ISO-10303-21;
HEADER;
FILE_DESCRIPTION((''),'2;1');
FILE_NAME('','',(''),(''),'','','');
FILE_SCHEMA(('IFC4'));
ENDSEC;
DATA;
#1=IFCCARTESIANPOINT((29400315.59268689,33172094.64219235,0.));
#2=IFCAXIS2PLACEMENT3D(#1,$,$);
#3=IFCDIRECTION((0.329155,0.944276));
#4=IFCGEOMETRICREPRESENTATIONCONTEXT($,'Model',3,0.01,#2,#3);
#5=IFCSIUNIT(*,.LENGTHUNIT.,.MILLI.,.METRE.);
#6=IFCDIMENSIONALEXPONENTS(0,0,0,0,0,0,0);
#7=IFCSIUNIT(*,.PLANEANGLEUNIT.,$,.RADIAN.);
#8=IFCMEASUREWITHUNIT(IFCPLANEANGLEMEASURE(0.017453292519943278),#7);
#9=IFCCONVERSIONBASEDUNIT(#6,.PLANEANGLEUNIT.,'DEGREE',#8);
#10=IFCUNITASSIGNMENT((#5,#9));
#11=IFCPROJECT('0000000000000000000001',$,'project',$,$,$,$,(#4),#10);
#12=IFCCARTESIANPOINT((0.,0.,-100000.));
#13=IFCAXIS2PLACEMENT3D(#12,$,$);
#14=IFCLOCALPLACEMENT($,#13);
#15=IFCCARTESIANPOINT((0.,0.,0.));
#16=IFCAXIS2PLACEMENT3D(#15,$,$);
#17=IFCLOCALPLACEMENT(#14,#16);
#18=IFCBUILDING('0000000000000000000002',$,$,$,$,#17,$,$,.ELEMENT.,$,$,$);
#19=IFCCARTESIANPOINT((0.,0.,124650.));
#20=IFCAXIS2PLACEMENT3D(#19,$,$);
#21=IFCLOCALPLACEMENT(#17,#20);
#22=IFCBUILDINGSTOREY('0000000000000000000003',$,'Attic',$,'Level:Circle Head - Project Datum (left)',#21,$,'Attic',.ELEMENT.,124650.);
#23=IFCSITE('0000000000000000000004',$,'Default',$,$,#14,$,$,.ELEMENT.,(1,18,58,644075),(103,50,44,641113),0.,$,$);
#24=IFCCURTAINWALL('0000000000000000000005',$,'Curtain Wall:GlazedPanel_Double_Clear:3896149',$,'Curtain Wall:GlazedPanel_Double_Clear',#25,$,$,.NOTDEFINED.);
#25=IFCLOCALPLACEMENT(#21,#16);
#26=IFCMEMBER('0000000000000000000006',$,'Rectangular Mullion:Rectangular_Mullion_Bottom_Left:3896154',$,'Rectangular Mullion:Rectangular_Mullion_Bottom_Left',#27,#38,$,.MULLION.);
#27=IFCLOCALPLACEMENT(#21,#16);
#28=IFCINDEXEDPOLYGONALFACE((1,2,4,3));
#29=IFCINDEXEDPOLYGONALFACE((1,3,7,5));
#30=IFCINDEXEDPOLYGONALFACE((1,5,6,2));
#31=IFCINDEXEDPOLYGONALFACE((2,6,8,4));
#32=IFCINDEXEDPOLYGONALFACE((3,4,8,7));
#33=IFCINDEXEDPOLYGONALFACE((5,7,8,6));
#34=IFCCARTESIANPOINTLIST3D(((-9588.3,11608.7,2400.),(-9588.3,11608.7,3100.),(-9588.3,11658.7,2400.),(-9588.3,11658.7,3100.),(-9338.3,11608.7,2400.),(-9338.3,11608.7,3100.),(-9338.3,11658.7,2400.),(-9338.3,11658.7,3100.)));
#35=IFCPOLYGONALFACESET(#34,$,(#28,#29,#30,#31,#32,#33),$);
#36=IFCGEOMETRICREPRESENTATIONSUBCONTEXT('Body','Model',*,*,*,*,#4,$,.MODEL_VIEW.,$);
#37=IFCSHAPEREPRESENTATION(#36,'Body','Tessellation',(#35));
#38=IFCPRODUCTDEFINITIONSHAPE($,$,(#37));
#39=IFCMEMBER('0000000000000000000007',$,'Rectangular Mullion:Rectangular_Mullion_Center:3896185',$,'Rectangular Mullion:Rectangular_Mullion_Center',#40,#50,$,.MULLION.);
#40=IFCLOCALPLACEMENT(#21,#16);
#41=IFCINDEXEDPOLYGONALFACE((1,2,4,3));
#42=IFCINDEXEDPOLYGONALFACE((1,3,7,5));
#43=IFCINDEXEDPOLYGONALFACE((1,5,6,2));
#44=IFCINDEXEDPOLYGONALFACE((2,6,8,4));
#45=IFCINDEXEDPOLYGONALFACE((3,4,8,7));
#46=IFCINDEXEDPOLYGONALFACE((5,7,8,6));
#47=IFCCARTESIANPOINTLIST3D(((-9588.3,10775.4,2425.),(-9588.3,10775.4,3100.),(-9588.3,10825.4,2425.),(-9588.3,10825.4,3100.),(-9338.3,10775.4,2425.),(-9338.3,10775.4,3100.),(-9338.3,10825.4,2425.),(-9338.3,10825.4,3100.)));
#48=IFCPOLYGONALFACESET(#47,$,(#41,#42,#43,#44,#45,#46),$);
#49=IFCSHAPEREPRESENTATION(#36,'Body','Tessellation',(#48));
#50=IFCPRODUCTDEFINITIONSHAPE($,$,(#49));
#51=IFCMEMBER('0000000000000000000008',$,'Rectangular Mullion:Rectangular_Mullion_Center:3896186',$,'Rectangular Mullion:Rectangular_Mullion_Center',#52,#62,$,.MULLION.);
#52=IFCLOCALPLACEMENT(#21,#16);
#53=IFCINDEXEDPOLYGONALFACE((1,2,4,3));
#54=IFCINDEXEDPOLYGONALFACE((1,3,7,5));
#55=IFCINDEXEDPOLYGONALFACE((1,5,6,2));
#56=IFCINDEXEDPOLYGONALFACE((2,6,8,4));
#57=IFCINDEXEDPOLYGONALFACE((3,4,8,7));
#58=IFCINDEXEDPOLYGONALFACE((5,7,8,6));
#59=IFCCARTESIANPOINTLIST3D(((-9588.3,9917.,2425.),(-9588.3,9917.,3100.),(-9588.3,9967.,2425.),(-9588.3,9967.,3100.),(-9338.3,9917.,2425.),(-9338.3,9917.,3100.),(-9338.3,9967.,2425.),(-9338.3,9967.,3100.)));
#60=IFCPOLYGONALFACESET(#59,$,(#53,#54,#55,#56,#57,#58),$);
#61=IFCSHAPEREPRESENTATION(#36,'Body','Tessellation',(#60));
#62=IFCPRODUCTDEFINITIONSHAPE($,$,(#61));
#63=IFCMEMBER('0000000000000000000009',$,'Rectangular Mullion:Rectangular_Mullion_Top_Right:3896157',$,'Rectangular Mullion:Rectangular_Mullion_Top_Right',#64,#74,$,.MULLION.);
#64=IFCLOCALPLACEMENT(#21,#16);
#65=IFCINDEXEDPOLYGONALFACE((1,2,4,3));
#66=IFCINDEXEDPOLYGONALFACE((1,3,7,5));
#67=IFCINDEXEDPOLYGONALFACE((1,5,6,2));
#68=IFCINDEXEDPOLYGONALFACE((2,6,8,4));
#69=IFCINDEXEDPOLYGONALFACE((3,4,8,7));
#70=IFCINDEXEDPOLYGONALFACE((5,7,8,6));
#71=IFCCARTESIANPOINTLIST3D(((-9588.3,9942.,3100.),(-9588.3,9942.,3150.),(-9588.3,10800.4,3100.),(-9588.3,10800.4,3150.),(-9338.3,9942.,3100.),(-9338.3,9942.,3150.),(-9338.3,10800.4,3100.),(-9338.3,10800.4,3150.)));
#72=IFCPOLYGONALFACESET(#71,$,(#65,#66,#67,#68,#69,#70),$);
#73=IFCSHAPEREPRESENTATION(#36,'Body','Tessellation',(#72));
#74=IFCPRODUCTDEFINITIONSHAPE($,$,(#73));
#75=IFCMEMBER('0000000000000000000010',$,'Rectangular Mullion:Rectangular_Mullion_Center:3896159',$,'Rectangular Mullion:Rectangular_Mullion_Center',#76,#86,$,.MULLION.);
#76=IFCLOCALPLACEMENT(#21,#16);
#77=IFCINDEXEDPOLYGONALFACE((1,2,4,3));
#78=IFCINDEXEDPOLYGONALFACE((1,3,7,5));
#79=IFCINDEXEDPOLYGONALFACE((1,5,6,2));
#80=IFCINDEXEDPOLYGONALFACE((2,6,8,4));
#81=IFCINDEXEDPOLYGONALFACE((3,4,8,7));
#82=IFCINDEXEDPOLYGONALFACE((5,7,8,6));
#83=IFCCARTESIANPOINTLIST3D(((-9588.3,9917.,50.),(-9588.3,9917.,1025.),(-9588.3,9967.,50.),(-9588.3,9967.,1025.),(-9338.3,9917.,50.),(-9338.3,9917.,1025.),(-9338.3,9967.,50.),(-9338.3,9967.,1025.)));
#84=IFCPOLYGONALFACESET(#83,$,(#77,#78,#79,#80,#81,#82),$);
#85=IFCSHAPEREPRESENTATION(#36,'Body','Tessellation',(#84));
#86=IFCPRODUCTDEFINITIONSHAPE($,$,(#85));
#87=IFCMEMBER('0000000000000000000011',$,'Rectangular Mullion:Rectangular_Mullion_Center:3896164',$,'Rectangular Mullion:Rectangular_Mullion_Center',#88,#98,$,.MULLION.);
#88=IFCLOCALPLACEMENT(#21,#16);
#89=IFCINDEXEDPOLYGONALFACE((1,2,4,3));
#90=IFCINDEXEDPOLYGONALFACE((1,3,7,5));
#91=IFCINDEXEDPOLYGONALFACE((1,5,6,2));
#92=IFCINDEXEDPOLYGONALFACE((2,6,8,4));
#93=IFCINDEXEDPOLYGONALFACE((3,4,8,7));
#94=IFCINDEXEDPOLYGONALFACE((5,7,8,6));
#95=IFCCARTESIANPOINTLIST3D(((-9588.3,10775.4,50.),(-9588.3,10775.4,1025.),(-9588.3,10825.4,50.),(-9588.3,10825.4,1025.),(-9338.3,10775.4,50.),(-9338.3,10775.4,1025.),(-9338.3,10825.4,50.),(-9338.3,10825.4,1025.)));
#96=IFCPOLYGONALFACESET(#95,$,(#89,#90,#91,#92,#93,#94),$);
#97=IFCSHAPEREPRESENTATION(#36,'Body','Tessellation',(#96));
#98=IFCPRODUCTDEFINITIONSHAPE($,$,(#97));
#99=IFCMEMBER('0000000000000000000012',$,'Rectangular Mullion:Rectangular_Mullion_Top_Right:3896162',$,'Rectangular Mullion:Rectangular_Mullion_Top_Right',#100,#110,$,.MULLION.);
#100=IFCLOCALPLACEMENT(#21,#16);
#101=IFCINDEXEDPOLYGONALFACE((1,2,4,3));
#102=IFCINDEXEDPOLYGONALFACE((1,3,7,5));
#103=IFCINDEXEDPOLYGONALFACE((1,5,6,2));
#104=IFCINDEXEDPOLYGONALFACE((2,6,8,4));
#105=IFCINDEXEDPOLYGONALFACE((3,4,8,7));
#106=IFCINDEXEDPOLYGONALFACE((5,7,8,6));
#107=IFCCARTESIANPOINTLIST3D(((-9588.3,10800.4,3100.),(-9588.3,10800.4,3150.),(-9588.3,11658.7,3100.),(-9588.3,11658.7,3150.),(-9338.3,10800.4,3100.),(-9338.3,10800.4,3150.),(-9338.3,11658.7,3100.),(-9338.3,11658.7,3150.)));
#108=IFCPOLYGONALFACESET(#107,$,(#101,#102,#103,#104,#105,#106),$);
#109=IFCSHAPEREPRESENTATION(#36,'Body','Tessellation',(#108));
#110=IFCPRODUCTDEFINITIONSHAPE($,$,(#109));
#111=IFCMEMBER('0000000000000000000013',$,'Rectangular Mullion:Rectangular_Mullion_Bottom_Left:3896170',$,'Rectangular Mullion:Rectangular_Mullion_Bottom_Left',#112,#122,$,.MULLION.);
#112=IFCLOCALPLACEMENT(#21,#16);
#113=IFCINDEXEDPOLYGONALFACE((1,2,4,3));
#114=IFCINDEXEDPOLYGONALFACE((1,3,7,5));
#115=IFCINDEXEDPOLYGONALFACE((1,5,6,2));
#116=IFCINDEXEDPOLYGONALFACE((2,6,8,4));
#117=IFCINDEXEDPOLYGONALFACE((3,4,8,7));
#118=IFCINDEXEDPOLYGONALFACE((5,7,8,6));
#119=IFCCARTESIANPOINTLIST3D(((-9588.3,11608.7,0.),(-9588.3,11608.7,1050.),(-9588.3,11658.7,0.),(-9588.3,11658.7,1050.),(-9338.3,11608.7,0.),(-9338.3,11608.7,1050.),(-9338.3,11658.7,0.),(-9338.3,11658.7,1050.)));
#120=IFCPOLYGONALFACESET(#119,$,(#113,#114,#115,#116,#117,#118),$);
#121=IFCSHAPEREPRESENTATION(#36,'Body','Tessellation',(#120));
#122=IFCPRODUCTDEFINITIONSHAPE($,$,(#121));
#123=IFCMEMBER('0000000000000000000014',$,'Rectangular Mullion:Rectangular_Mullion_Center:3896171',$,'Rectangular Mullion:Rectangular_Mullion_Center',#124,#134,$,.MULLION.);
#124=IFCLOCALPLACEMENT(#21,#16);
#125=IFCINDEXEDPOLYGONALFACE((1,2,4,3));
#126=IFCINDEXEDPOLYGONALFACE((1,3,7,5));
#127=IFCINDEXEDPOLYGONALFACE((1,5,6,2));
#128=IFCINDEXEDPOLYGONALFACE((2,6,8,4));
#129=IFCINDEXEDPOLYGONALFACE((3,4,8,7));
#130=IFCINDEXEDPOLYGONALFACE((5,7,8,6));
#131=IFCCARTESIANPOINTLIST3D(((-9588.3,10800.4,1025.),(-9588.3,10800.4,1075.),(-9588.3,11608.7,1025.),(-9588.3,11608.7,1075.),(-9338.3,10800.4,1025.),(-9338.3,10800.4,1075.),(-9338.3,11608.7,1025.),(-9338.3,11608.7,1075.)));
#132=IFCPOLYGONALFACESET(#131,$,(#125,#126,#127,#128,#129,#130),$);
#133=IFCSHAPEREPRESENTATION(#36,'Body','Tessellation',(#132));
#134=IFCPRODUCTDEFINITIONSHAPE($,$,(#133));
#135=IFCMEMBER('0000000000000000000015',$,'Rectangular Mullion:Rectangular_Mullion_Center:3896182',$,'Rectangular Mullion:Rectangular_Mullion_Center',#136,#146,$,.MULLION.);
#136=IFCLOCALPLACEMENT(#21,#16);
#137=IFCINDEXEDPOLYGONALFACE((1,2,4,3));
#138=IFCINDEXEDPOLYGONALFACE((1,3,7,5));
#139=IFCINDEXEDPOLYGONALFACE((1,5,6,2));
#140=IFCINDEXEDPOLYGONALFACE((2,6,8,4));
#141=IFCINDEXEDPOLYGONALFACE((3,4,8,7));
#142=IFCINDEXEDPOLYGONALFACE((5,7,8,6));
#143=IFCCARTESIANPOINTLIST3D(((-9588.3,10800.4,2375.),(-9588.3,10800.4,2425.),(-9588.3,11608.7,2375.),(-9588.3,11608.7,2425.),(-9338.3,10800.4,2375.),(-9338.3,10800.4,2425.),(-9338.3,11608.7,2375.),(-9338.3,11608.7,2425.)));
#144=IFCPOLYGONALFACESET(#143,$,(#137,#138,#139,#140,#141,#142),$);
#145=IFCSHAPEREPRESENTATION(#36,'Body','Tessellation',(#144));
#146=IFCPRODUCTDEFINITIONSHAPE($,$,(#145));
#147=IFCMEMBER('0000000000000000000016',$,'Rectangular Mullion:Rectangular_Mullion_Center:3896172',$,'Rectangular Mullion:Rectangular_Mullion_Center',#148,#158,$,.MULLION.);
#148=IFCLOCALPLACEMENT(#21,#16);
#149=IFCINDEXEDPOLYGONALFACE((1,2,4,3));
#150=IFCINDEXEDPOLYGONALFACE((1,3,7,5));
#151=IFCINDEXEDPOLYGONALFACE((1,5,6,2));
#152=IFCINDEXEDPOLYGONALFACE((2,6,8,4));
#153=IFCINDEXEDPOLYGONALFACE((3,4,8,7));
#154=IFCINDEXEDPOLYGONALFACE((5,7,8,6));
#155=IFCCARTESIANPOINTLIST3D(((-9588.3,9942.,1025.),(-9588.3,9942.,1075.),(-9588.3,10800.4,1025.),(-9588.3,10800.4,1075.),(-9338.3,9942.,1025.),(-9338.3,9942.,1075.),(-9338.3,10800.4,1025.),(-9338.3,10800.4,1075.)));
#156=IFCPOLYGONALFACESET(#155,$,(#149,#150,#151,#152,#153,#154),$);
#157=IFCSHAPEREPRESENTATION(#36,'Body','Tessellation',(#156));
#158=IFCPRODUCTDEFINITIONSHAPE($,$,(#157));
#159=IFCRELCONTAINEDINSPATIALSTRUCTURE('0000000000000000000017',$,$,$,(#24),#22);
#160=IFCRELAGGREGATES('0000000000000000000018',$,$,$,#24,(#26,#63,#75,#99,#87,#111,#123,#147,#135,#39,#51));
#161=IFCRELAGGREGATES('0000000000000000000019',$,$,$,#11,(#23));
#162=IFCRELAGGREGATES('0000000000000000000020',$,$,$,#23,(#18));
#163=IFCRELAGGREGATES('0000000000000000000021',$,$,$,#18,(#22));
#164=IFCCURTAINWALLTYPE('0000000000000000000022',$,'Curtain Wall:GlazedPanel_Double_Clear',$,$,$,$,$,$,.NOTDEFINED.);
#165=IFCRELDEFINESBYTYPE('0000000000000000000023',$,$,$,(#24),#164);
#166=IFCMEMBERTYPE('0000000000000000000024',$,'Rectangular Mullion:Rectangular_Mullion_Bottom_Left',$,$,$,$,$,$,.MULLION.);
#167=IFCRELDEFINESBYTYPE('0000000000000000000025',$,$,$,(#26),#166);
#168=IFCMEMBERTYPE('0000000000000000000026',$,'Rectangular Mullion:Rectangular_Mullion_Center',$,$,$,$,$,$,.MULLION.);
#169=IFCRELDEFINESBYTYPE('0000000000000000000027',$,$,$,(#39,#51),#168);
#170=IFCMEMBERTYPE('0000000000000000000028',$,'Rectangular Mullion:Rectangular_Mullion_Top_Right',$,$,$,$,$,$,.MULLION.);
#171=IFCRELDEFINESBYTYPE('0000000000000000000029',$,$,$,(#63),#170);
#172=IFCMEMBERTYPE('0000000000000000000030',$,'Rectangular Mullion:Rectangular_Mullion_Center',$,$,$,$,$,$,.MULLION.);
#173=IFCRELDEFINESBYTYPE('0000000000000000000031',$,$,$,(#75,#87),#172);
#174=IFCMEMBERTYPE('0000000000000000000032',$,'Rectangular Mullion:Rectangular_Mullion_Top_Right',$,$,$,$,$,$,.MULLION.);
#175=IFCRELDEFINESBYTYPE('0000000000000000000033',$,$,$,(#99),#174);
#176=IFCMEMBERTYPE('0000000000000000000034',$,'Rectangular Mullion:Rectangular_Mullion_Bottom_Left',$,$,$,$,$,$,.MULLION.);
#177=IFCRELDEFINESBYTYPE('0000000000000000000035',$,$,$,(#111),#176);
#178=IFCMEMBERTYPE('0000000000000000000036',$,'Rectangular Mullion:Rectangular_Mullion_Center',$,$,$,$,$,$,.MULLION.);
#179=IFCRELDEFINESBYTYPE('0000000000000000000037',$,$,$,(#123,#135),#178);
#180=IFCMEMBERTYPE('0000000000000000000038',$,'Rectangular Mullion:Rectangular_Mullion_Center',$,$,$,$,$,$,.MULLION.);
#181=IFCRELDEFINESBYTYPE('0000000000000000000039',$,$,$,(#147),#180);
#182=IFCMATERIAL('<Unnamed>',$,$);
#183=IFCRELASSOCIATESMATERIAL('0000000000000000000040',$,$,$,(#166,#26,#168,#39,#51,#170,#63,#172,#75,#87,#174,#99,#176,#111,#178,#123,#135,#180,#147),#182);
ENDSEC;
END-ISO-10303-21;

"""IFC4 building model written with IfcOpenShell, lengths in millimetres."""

from ifc_helpers import new_model, entity, si_unit, converted_unit, direction, frame, origin, place, context, subcontext, project, spatial, indexed_curve, outline, extrude, source, transform, mapped, material, type_object, type_shapes, element, aggregate, save


model = new_model("IFC4")

# Units and contexts
model_context = context("Model", 3, precision=0.01, world=frame((29400315.59268689, 33172094.64219235, 0.0)), true_north=direction((0.329155, 0.944276)))
body_context = subcontext(model_context, "Body", "Model", "MODEL_VIEW")
ifc_project = project(units=[si_unit("LENGTHUNIT", "METRE", prefix="MILLI"), converted_unit("PLANEANGLEUNIT", "DEGREE", entity("IfcPlaneAngleMeasure", 0.017453292519943278), si_unit("PLANEANGLEUNIT", "RADIAN"), dimensions=[0, 0, 0, 0, 0, 0, 0])], contexts=[model_context])

# Site, building, storey
site_placement = place(None, frame((0.0, 0.0, -100000.0)))
site = spatial("IfcSite", under=ifc_project, at=site_placement, Name="Default", CompositionType="ELEMENT", RefLatitude=(1, 18, 58, 644075), RefLongitude=(103, 50, 44, 641113), RefElevation=0.0)
building_placement = place(site_placement, origin())
building = spatial("IfcBuilding", under=site, at=building_placement, CompositionType="ELEMENT")
storey_placement = place(building_placement, frame((0.0, 0.0, 124650.0)))
storey = spatial("IfcBuildingStorey", under=building, at=storey_placement, Name="Attic", ObjectType="Level:Circle Head - Project Datum (left)", LongName="Attic", CompositionType="ELEMENT", Elevation=124650.0)

# Curtain wall, members
curtain_wall_type = type_object("IfcCurtainWallType", Name="Curtain Wall:GlazedPanel_Double_Clear", PredefinedType="NOTDEFINED")
curtain_wall_placement = place(storey_placement, frame((0.0, 0.0, -124650.0)))
curtain_wall = element("IfcCurtainWall", 1, at=curtain_wall_placement, inside=storey, type_object=curtain_wall_type, Name="Curtain Wall:GlazedPanel_Double_Clear:3896149", ObjectType="Curtain Wall:GlazedPanel_Double_Clear", PredefinedType="NOTDEFINED")
ifc_material_1 = material(Name="<Unnamed>")
member_type_1 = type_object("IfcMemberType", Name="Rectangular Mullion:Rectangular_Mullion_Bottom_Left", PredefinedType="MULLION", material=ifc_material_1)
shared_shape_1 = source(origin(), body_context, "Body", "SweptSolid", [
    extrude(outline(indexed_curve([(-25.0, -125.0), (25.0, -125.0), (25.0, 125.0), (-25.0, 125.0), (-25.0, -125.0)], self_intersect=False)), frame((-25.0, 0.0, -700.0), z_axis=(0.0, 0.0, 1.0), x_axis=(-1.0, 0.0, 0.0)), (0.0, 0.0, 1.0), 700.0),
])
type_shapes(member_type_1, [shared_shape_1])
member_1_placement = place(curtain_wall_placement, frame((-9463.3, 11658.7, 127750.0), z_axis=(0.0, 0.0, 1.0), x_axis=(0.0, 1.0, 0.0)))
member_1 = element("IfcMember", 2, at=member_1_placement, type_object=member_type_1, material=ifc_material_1, Name="Rectangular Mullion:Rectangular_Mullion_Bottom_Left:3896154", ObjectType="Rectangular Mullion:Rectangular_Mullion_Bottom_Left", PredefinedType="MULLION", context=body_context, shape_type="MappedRepresentation", body=[
    mapped(shared_shape_1, transform((0.0, 0.0, 0.0), scale=1.0)),
])
member_type_2 = type_object("IfcMemberType", Name="Rectangular Mullion:Rectangular_Mullion_Center", PredefinedType="MULLION", material=ifc_material_1)
shared_shape_2 = source(origin(), body_context, "Body", "SweptSolid", [
    extrude(outline(indexed_curve([(-25.0, -125.0), (25.0, -125.0), (25.0, 125.0), (-25.0, 125.0), (-25.0, -125.0)], self_intersect=False)), frame((0.0, 0.0, -675.0), z_axis=(0.0, 0.0, 1.0), x_axis=(-1.0, 0.0, 0.0)), (0.0, 0.0, 1.0), 675.0),
])
type_shapes(member_type_2, [shared_shape_2])
member_2_placement = place(curtain_wall_placement, frame((-9463.3, 10800.4, 127075.0), z_axis=(0.0, 0.0, -1.0), x_axis=(0.0, -1.0, 0.0)))
member_2 = element("IfcMember", 3, at=member_2_placement, type_object=member_type_2, material=ifc_material_1, Name="Rectangular Mullion:Rectangular_Mullion_Center:3896185", ObjectType="Rectangular Mullion:Rectangular_Mullion_Center", PredefinedType="MULLION", context=body_context, shape_type="MappedRepresentation", body=[
    mapped(shared_shape_2, transform((0.0, 0.0, 0.0), scale=1.0)),
])
member_3_placement = place(curtain_wall_placement, frame((-9463.3, 9942.0, 127075.0), z_axis=(0.0, 0.0, -1.0), x_axis=(0.0, -1.0, 0.0)))
member_3 = element("IfcMember", 4, at=member_3_placement, type_object=member_type_2, material=ifc_material_1, Name="Rectangular Mullion:Rectangular_Mullion_Center:3896186", ObjectType="Rectangular Mullion:Rectangular_Mullion_Center", PredefinedType="MULLION", context=body_context, shape_type="MappedRepresentation", body=[
    mapped(shared_shape_2, transform((0.0, 0.0, 0.0), scale=1.0)),
])
member_type_3 = type_object("IfcMemberType", Name="Rectangular Mullion:Rectangular_Mullion_Top_Right", PredefinedType="MULLION", material=ifc_material_1)
shared_shape_3 = source(origin(), body_context, "Body", "SweptSolid", [
    extrude(outline(indexed_curve([(-25.0, -125.0), (25.0, -125.0), (25.0, 125.0), (-25.0, 125.0), (-25.0, -125.0)], self_intersect=False)), frame((-25.0, 0.0, -858.3), z_axis=(0.0, 0.0, 1.0), x_axis=(-1.0, 0.0, 0.0)), (0.0, 0.0, 1.0), 858.3),
])
type_shapes(member_type_3, [shared_shape_3])
member_4_placement = place(curtain_wall_placement, frame((-9463.3, 9942.0, 127800.0), z_axis=(0.0, -1.0, 0.0), x_axis=(0.0, 0.0, 1.0)))
member_4 = element("IfcMember", 5, at=member_4_placement, type_object=member_type_3, material=ifc_material_1, Name="Rectangular Mullion:Rectangular_Mullion_Top_Right:3896157", ObjectType="Rectangular Mullion:Rectangular_Mullion_Top_Right", PredefinedType="MULLION", context=body_context, shape_type="MappedRepresentation", body=[
    mapped(shared_shape_3, transform((0.0, 0.0, 0.0), scale=1.0)),
])
member_type_4 = type_object("IfcMemberType", Name="Rectangular Mullion:Rectangular_Mullion_Center", PredefinedType="MULLION", material=ifc_material_1)
shared_shape_4 = source(origin(), body_context, "Body", "SweptSolid", [
    extrude(outline(indexed_curve([(-25.0, -125.0), (25.0, -125.0), (25.0, 125.0), (-25.0, 125.0), (-25.0, -125.0)], self_intersect=False)), frame((0.0, 0.0, -975.0), z_axis=(0.0, 0.0, 1.0), x_axis=(-1.0, 0.0, 0.0)), (0.0, 0.0, 1.0), 975.0),
])
type_shapes(member_type_4, [shared_shape_4])
member_5_placement = place(curtain_wall_placement, frame((-9463.3, 9942.0, 124700.0), z_axis=(0.0, 0.0, -1.0), x_axis=(0.0, -1.0, 0.0)))
member_5 = element("IfcMember", 6, at=member_5_placement, type_object=member_type_4, material=ifc_material_1, Name="Rectangular Mullion:Rectangular_Mullion_Center:3896159", ObjectType="Rectangular Mullion:Rectangular_Mullion_Center", PredefinedType="MULLION", context=body_context, shape_type="MappedRepresentation", body=[
    mapped(shared_shape_4, transform((0.0, 0.0, 0.0), scale=1.0)),
])
member_6_placement = place(curtain_wall_placement, frame((-9463.3, 10800.4, 124700.0), z_axis=(0.0, 0.0, -1.0), x_axis=(0.0, -1.0, 0.0)))
member_6 = element("IfcMember", 7, at=member_6_placement, type_object=member_type_4, material=ifc_material_1, Name="Rectangular Mullion:Rectangular_Mullion_Center:3896164", ObjectType="Rectangular Mullion:Rectangular_Mullion_Center", PredefinedType="MULLION", context=body_context, shape_type="MappedRepresentation", body=[
    mapped(shared_shape_4, transform((0.0, 0.0, 0.0), scale=1.0)),
])
member_type_5 = type_object("IfcMemberType", Name="Rectangular Mullion:Rectangular_Mullion_Top_Right", PredefinedType="MULLION", material=ifc_material_1)
shared_shape_5 = source(origin(), body_context, "Body", "SweptSolid", [
    extrude(outline(indexed_curve([(-25.0, -125.0), (25.0, -125.0), (25.0, 125.0), (-25.0, 125.0), (-25.0, -125.0)], self_intersect=False)), frame((-25.0, 0.0, -858.3), z_axis=(0.0, 0.0, 1.0), x_axis=(-1.0, 0.0, 0.0)), (0.0, 0.0, 1.0), 858.3),
])
type_shapes(member_type_5, [shared_shape_5])
member_7_placement = place(curtain_wall_placement, frame((-9463.3, 10800.4, 127800.0), z_axis=(0.0, -1.0, 0.0), x_axis=(0.0, 0.0, 1.0)))
member_7 = element("IfcMember", 8, at=member_7_placement, type_object=member_type_5, material=ifc_material_1, Name="Rectangular Mullion:Rectangular_Mullion_Top_Right:3896162", ObjectType="Rectangular Mullion:Rectangular_Mullion_Top_Right", PredefinedType="MULLION", context=body_context, shape_type="MappedRepresentation", body=[
    mapped(shared_shape_5, transform((0.0, 0.0, 0.0), scale=1.0)),
])
member_type_6 = type_object("IfcMemberType", Name="Rectangular Mullion:Rectangular_Mullion_Bottom_Left", PredefinedType="MULLION", material=ifc_material_1)
shared_shape_6 = source(origin(), body_context, "Body", "SweptSolid", [
    extrude(outline(indexed_curve([(-25.0, -125.0), (25.0, -125.0), (25.0, 125.0), (-25.0, 125.0), (-25.0, -125.0)], self_intersect=False)), frame((-25.0, 0.0, -1050.0), z_axis=(0.0, 0.0, 1.0), x_axis=(-1.0, 0.0, 0.0)), (0.0, 0.0, 1.0), 1050.0),
])
type_shapes(member_type_6, [shared_shape_6])
member_8_placement = place(curtain_wall_placement, frame((-9463.3, 11658.7, 125700.0), z_axis=(0.0, 0.0, 1.0), x_axis=(0.0, 1.0, 0.0)))
member_8 = element("IfcMember", 9, at=member_8_placement, type_object=member_type_6, material=ifc_material_1, Name="Rectangular Mullion:Rectangular_Mullion_Bottom_Left:3896170", ObjectType="Rectangular Mullion:Rectangular_Mullion_Bottom_Left", PredefinedType="MULLION", context=body_context, shape_type="MappedRepresentation", body=[
    mapped(shared_shape_6, transform((0.0, 0.0, 0.0), scale=1.0)),
])
member_type_7 = type_object("IfcMemberType", Name="Rectangular Mullion:Rectangular_Mullion_Center", PredefinedType="MULLION", material=ifc_material_1)
shared_shape_7 = source(origin(), body_context, "Body", "SweptSolid", [
    extrude(outline(indexed_curve([(-25.0, -125.0), (25.0, -125.0), (25.0, 125.0), (-25.0, 125.0), (-25.0, -125.0)], self_intersect=False)), frame((0.0, 0.0, -808.3), z_axis=(0.0, 0.0, 1.0), x_axis=(-1.0, 0.0, 0.0)), (0.0, 0.0, 1.0), 808.3),
])
type_shapes(member_type_7, [shared_shape_7])
member_9_placement = place(curtain_wall_placement, frame((-9463.3, 10800.4, 125700.0), z_axis=(0.0, -1.0, 0.0), x_axis=(0.0, 0.0, 1.0)))
member_9 = element("IfcMember", 10, at=member_9_placement, type_object=member_type_7, material=ifc_material_1, Name="Rectangular Mullion:Rectangular_Mullion_Center:3896171", ObjectType="Rectangular Mullion:Rectangular_Mullion_Center", PredefinedType="MULLION", context=body_context, shape_type="MappedRepresentation", body=[
    mapped(shared_shape_7, transform((0.0, 0.0, 0.0), scale=1.0)),
])
member_10_placement = place(curtain_wall_placement, frame((-9463.3, 10800.4, 127050.0), z_axis=(0.0, -1.0, 0.0), x_axis=(0.0, 0.0, 1.0)))
member_10 = element("IfcMember", 11, at=member_10_placement, type_object=member_type_7, material=ifc_material_1, Name="Rectangular Mullion:Rectangular_Mullion_Center:3896182", ObjectType="Rectangular Mullion:Rectangular_Mullion_Center", PredefinedType="MULLION", context=body_context, shape_type="MappedRepresentation", body=[
    mapped(shared_shape_7, transform((0.0, 0.0, 0.0), scale=1.0)),
])
member_type_8 = type_object("IfcMemberType", Name="Rectangular Mullion:Rectangular_Mullion_Center", PredefinedType="MULLION", material=ifc_material_1)
shared_shape_8 = source(origin(), body_context, "Body", "SweptSolid", [
    extrude(outline(indexed_curve([(-25.0, -125.0), (25.0, -125.0), (25.0, 125.0), (-25.0, 125.0), (-25.0, -125.0)], self_intersect=False)), frame((0.0, 0.0, -858.3), z_axis=(0.0, 0.0, 1.0), x_axis=(-1.0, 0.0, 0.0)), (0.0, 0.0, 1.0), 858.3),
])
type_shapes(member_type_8, [shared_shape_8])
member_11_placement = place(curtain_wall_placement, frame((-9463.3, 9942.0, 125700.0), z_axis=(0.0, -1.0, 0.0), x_axis=(0.0, 0.0, 1.0)))
member_11 = element("IfcMember", 12, at=member_11_placement, type_object=member_type_8, material=ifc_material_1, Name="Rectangular Mullion:Rectangular_Mullion_Center:3896172", ObjectType="Rectangular Mullion:Rectangular_Mullion_Center", PredefinedType="MULLION", context=body_context, shape_type="MappedRepresentation", body=[
    mapped(shared_shape_8, transform((0.0, 0.0, 0.0), scale=1.0)),
])
aggregate(curtain_wall, [member_1, member_4, member_5, member_7, member_6, member_8, member_9, member_11, member_10, member_2, member_3])

save(model, "model.ifc")
